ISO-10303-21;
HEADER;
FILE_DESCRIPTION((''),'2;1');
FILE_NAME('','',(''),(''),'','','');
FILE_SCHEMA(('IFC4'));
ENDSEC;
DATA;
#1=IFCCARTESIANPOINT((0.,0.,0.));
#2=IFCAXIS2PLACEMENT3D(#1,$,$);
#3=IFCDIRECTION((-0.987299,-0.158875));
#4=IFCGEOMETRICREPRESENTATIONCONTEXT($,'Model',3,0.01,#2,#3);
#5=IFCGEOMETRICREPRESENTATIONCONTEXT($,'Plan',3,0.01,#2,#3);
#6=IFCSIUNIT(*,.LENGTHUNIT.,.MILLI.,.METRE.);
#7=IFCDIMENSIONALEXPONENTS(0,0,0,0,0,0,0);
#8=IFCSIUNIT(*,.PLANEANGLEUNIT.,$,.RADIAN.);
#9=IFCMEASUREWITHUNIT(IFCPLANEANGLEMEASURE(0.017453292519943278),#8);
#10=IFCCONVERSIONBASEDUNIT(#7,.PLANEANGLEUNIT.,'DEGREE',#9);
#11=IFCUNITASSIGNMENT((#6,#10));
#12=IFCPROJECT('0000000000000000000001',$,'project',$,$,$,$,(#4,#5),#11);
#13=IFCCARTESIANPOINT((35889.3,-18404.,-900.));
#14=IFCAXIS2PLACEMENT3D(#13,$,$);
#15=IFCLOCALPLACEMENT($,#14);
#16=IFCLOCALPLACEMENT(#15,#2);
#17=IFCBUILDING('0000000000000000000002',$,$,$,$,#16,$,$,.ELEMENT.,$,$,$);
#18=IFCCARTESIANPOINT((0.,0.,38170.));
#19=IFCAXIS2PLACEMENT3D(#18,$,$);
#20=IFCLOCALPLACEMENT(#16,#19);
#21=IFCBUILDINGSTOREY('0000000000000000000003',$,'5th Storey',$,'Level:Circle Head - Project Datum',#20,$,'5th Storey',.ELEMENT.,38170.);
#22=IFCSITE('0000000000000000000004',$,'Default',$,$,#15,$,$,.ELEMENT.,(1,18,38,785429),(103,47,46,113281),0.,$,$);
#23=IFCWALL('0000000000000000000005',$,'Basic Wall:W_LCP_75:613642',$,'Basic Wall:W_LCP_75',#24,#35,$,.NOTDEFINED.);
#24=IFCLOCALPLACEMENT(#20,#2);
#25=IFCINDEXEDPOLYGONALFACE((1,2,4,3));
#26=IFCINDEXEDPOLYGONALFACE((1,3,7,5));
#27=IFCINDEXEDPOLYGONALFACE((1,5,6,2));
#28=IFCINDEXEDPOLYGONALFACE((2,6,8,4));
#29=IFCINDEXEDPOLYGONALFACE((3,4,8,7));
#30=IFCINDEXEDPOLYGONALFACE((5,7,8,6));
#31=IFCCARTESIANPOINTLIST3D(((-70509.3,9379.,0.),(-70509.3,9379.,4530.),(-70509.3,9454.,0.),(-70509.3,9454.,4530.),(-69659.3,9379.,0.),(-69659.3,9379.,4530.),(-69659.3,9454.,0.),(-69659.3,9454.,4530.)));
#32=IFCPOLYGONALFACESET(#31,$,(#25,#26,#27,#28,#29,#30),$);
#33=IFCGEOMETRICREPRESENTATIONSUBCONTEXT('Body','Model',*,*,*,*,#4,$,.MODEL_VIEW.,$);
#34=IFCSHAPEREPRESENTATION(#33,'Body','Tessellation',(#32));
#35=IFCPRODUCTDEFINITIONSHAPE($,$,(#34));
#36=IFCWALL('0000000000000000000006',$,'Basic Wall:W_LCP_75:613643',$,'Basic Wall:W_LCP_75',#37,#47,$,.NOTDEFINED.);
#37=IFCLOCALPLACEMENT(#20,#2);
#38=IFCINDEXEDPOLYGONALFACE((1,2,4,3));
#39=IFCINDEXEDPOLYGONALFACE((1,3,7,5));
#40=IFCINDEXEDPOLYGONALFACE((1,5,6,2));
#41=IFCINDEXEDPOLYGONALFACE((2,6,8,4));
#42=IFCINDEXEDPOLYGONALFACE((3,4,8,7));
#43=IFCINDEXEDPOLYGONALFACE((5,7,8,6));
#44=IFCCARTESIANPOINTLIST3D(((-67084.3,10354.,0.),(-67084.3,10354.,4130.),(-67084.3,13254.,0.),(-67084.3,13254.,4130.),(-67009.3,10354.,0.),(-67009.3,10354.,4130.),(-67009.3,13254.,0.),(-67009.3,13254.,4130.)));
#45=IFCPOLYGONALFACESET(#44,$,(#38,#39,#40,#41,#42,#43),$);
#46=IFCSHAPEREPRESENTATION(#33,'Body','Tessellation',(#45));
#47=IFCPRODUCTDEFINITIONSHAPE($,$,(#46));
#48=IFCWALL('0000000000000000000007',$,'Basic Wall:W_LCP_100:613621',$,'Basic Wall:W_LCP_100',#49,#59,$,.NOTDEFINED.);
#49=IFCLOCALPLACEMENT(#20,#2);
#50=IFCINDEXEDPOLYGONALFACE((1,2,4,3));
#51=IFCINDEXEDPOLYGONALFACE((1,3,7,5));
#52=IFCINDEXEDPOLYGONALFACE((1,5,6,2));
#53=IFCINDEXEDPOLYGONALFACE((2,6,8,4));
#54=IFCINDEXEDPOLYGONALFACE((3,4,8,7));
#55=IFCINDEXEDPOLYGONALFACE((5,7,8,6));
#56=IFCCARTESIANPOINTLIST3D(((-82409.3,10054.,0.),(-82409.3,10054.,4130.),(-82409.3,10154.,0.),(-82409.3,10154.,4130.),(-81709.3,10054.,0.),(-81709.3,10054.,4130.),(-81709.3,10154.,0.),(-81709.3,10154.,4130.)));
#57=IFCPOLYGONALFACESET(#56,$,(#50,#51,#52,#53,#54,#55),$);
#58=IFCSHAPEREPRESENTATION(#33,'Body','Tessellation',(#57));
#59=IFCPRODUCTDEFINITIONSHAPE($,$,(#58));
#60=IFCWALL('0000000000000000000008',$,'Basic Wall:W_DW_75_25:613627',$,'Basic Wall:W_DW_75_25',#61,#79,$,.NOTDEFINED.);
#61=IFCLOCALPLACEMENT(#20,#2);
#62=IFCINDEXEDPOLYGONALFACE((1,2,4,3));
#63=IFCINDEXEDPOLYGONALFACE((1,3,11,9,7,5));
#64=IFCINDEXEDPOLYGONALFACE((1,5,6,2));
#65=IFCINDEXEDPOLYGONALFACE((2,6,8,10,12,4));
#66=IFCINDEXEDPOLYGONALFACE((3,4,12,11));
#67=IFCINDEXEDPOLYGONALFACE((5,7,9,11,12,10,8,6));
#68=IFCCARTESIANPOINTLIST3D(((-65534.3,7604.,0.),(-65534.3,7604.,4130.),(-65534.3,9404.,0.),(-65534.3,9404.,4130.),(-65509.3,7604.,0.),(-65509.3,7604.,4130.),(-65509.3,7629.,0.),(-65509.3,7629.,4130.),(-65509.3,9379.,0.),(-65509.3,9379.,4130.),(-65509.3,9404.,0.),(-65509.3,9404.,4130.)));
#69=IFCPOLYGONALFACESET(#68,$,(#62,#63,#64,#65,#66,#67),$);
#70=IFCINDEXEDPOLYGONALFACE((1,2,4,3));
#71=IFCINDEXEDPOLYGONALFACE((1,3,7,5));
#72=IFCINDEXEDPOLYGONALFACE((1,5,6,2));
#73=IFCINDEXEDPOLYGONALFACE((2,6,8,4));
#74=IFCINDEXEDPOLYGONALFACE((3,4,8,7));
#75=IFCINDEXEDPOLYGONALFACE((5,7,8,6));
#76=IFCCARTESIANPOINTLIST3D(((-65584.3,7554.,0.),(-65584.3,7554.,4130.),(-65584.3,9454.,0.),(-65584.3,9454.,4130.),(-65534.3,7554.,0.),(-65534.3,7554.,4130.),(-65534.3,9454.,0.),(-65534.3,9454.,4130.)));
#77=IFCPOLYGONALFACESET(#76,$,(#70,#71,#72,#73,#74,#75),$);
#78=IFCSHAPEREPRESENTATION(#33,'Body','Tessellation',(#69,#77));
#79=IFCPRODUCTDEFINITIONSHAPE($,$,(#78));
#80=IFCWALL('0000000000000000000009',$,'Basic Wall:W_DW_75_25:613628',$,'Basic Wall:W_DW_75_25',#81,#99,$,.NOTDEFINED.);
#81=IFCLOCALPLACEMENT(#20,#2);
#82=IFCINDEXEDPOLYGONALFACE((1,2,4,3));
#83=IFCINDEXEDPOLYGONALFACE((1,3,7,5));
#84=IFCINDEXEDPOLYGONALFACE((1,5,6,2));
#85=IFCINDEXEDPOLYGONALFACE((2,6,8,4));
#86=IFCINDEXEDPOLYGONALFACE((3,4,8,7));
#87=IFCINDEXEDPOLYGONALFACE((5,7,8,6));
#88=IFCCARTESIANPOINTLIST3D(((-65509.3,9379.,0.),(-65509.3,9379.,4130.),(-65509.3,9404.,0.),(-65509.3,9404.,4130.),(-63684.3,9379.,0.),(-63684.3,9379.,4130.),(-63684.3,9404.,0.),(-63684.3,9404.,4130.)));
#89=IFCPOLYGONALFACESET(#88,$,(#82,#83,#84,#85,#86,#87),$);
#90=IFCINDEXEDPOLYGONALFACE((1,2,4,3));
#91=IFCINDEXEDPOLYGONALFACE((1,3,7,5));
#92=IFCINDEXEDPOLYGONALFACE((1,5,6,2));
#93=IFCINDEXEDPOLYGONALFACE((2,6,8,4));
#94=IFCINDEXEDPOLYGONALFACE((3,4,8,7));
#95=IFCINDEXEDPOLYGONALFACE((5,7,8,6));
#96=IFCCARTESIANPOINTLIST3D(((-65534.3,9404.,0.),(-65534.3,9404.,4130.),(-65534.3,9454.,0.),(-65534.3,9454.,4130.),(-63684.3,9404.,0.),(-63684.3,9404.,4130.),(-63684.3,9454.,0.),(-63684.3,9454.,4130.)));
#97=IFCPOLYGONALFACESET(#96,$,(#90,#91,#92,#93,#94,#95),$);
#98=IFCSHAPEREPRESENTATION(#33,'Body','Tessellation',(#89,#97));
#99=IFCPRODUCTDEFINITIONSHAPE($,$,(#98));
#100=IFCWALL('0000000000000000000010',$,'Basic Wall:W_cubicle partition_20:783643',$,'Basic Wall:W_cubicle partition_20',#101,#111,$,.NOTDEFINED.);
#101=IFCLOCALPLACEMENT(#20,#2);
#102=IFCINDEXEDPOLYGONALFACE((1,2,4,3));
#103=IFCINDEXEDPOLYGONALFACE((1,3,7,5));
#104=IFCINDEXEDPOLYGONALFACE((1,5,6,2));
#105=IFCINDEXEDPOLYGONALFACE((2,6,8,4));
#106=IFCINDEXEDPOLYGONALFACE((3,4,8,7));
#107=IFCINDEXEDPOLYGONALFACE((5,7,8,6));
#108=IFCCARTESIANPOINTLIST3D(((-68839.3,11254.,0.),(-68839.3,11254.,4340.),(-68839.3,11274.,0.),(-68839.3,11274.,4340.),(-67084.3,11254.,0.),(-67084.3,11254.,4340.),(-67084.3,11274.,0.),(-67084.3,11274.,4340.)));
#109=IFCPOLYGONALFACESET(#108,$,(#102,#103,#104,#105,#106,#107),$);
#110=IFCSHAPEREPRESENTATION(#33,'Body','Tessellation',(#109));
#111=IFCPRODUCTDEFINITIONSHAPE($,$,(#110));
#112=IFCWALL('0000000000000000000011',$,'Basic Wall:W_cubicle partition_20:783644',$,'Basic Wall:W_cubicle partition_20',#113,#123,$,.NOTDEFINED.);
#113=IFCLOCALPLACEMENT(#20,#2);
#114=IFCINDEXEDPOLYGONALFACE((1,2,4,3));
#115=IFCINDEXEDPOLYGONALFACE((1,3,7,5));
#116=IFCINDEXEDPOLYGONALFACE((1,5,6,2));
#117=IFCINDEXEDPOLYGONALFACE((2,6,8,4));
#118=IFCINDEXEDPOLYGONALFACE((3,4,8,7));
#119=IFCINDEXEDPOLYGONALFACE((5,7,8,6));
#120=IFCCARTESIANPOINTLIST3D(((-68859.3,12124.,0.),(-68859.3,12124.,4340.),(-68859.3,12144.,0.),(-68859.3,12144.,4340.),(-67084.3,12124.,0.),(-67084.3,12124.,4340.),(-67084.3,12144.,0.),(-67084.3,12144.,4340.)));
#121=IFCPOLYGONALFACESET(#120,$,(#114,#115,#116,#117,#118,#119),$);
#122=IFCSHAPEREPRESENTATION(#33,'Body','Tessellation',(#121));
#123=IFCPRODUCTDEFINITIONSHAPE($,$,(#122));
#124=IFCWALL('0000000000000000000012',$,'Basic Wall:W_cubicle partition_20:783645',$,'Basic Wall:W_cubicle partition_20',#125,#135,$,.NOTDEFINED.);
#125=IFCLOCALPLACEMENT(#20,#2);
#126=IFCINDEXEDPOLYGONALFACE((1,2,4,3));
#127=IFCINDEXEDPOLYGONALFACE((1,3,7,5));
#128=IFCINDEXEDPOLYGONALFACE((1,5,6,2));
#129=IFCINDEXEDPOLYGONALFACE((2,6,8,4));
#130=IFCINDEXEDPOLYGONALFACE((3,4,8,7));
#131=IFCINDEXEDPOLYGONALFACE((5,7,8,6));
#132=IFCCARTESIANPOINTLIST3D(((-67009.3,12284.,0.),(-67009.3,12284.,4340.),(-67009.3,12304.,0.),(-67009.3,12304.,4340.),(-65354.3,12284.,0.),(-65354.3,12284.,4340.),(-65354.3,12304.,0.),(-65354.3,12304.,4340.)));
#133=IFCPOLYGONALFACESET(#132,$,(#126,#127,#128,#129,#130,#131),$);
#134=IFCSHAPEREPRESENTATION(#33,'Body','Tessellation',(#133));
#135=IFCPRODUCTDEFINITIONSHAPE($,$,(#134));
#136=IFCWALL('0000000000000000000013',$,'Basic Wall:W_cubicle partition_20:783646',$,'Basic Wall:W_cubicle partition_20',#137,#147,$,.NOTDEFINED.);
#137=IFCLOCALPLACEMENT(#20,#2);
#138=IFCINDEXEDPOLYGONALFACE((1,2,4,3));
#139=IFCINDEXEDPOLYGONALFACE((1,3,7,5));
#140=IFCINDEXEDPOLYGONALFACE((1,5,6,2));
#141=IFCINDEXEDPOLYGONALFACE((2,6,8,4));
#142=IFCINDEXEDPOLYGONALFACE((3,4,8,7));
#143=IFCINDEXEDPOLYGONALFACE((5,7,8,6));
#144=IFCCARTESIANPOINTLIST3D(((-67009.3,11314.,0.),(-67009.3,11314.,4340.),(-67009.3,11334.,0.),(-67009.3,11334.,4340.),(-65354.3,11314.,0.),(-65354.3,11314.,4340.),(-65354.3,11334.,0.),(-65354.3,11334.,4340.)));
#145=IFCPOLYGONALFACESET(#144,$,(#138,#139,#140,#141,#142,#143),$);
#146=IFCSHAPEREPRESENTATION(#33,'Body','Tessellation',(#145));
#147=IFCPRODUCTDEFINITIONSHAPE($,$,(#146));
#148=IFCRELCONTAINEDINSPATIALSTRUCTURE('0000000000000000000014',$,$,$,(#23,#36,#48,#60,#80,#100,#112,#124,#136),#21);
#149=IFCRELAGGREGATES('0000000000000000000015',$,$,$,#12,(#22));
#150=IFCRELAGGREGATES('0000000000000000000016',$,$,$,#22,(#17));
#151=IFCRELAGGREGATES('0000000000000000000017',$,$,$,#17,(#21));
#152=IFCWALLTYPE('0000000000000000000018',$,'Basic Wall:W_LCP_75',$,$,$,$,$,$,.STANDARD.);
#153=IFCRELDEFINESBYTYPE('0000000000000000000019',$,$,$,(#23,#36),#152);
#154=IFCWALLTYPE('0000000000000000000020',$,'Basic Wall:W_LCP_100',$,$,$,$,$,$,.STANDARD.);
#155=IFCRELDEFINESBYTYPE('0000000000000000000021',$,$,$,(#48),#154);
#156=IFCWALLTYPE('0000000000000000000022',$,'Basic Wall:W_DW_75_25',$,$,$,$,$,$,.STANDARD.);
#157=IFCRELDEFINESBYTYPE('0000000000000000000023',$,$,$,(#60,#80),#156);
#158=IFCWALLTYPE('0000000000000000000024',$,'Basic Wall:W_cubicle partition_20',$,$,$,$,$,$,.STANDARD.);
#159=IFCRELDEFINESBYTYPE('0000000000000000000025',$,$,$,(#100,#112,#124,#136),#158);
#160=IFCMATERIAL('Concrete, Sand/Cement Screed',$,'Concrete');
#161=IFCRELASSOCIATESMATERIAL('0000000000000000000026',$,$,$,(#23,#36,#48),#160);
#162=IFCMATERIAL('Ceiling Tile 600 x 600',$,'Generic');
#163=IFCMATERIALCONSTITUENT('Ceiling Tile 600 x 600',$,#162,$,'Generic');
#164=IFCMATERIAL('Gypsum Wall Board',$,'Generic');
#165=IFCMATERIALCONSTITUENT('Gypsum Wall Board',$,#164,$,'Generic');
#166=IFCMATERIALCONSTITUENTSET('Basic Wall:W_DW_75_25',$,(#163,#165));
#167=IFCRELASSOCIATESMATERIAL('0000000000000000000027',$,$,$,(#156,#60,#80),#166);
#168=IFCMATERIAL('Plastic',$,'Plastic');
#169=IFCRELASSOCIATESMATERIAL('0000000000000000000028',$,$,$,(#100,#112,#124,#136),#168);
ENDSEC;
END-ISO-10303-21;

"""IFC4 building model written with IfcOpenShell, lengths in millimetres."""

from ifc_helpers import new_model, entity, si_unit, converted_unit, direction, frame, origin, place, context, subcontext, project, spatial, indexed_curve, outline, extrude, material, constituent, constituent_set, type_object, element, save


model = new_model("IFC4")

# Units and contexts
model_context = context("Model", 3, precision=0.01, world=origin(), true_north=direction((-0.987299, -0.158875)))
plan_context = context("Plan", 3, precision=0.01, world=origin(), true_north=direction((-0.987299, -0.158875)))
body_context = subcontext(model_context, "Body", "Model", "MODEL_VIEW")
ifc_project = project(units=[si_unit("LENGTHUNIT", "METRE", prefix="MILLI"), converted_unit("PLANEANGLEUNIT", "DEGREE", entity("IfcPlaneAngleMeasure", 0.017453292519943278), si_unit("PLANEANGLEUNIT", "RADIAN"), dimensions=[0, 0, 0, 0, 0, 0, 0])], contexts=[model_context, plan_context])

# Site, building, storey
site_placement = place(None, frame((35889.3, -18404.0, -900.0)))
site = spatial("IfcSite", under=ifc_project, at=site_placement, Name="Default", CompositionType="ELEMENT", RefLatitude=(1, 18, 38, 785429), RefLongitude=(103, 47, 46, 113281), RefElevation=0.0)
building_placement = place(site_placement, origin())
building = spatial("IfcBuilding", under=site, at=building_placement, CompositionType="ELEMENT")
storey_placement = place(building_placement, frame((0.0, 0.0, 38170.0)))
storey = spatial("IfcBuildingStorey", under=building, at=storey_placement, Name="5th Storey", ObjectType="Level:Circle Head - Project Datum", LongName="5th Storey", CompositionType="ELEMENT", Elevation=38170.0)

# Walls
ifc_material_1 = material(Name="Concrete, Sand/Cement Screed", Category="Concrete")
wall_type_1 = type_object("IfcWallType", Name="Basic Wall:W_LCP_75", PredefinedType="STANDARD")
wall_1_placement = place(storey_placement, frame((-70509.3, 9416.5, 0.0)))
element("IfcWall", 1, at=wall_1_placement, inside=storey, type_object=wall_type_1, material=ifc_material_1, Name="Basic Wall:W_LCP_75:613642", ObjectType="Basic Wall:W_LCP_75", PredefinedType="NOTDEFINED", context=body_context, shape_type="SweptSolid", body=[
    extrude(outline(indexed_curve([(850.0, 37.5), (0.0, 37.5), (0.0, -37.5), (850.0, -37.5), (850.0, 37.5)], self_intersect=False)), origin(), (0.0, 0.0, 1.0), 4530.0),
])
wall_2_placement = place(storey_placement, frame((-67046.8, 13254.0, 0.0), z_axis=(0.0, 0.0, 1.0), x_axis=(0.0, -1.0, 0.0)))
element("IfcWall", 2, at=wall_2_placement, inside=storey, type_object=wall_type_1, material=ifc_material_1, Name="Basic Wall:W_LCP_75:613643", ObjectType="Basic Wall:W_LCP_75", PredefinedType="NOTDEFINED", context=body_context, shape_type="SweptSolid", body=[
    extrude(outline(indexed_curve([(2900.0, 37.5), (0.0, 37.5), (0.0, -37.5), (2900.0, -37.5), (2900.0, 37.5)], self_intersect=False)), origin(), (0.0, 0.0, 1.0), 4130.0),
])
wall_type_2 = type_object("IfcWallType", Name="Basic Wall:W_LCP_100", PredefinedType="STANDARD")
wall_3_placement = place(storey_placement, frame((-81709.3, 10104.0, 0.0), z_axis=(0.0, 0.0, 1.0), x_axis=(-1.0, 0.0, 0.0)))
element("IfcWall", 3, at=wall_3_placement, inside=storey, type_object=wall_type_2, material=ifc_material_1, Name="Basic Wall:W_LCP_100:613621", ObjectType="Basic Wall:W_LCP_100", PredefinedType="NOTDEFINED", context=body_context, shape_type="SweptSolid", body=[
    extrude(outline(indexed_curve([(700.0, 50.0), (0.0, 50.0), (0.0, -50.0), (700.0, -50.0), (700.0, 50.0)], self_intersect=False)), origin(), (0.0, 0.0, 1.0), 4130.0),
])
ifc_material_2 = material(Name="Ceiling Tile 600 x 600", Category="Generic")
ifc_constituent_1 = constituent(ifc_material_2, Name="Ceiling Tile 600 x 600", Category="Generic")
ifc_material_3 = material(Name="Gypsum Wall Board", Category="Generic")
ifc_constituent_2 = constituent(ifc_material_3, Name="Gypsum Wall Board", Category="Generic")
ifc_constituent_set = constituent_set(constituents=[ifc_constituent_1, ifc_constituent_2], Name="Basic Wall:W_DW_75_25")
wall_type_3 = type_object("IfcWallType", Name="Basic Wall:W_DW_75_25", PredefinedType="STANDARD", material=ifc_constituent_set)
wall_4_placement = place(storey_placement, frame((-65546.8, 9454.0, 0.0), z_axis=(0.0, 0.0, 1.0), x_axis=(0.0, -1.0, 0.0)))
element("IfcWall", 4, at=wall_4_placement, inside=storey, type_object=wall_type_3, material=ifc_constituent_set, Name="Basic Wall:W_DW_75_25:613627", ObjectType="Basic Wall:W_DW_75_25", PredefinedType="NOTDEFINED", context=body_context, shape_type="SweptSolid", body=[
    extrude(outline(indexed_curve([(-875.0, -8.3), (875.0, -8.3), (900.0, -8.3), (900.0, 16.7), (-900.0, 16.7), (-900.0, -8.3), (-875.0, -8.3)], self_intersect=False)), frame((950.0, 29.2, 0.0), z_axis=(0.0, 0.0, 1.0), x_axis=(-1.0, 0.0, 0.0)), (0.0, 0.0, 1.0), 4130.0),
    extrude(outline(indexed_curve([(-25.0, -950.0), (25.0, -950.0), (25.0, 950.0), (-25.0, 950.0), (-25.0, -950.0)], self_intersect=False)), frame((950.0, -12.5, 0.0), z_axis=(0.0, 0.0, 1.0), x_axis=(0.0, 1.0, 0.0)), (0.0, 0.0, 1.0), 4130.0),
])
wall_5_placement = place(storey_placement, frame((-65509.3, 9416.5, 0.0)))
element("IfcWall", 5, at=wall_5_placement, inside=storey, type_object=wall_type_3, material=ifc_constituent_set, Name="Basic Wall:W_DW_75_25:613628", ObjectType="Basic Wall:W_DW_75_25", PredefinedType="NOTDEFINED", context=body_context, shape_type="SweptSolid", body=[
    extrude(outline(indexed_curve([(-12.5, -912.5), (12.5, -912.5), (12.5, 912.5), (-12.5, 912.5), (-12.5, -912.5)], self_intersect=False)), frame((912.5, -25.0, 0.0), z_axis=(0.0, 0.0, 1.0), x_axis=(0.0, 1.0, 0.0)), (0.0, 0.0, 1.0), 4130.0),
    extrude(outline(indexed_curve([(-25.0, -925.0), (25.0, -925.0), (25.0, 925.0), (-25.0, 925.0), (-25.0, -925.0)], self_intersect=False)), frame((900.0, 12.5, 0.0), z_axis=(0.0, 0.0, 1.0), x_axis=(0.0, -1.0, 0.0)), (0.0, 0.0, 1.0), 4130.0),
])
ifc_material_4 = material(Name="Plastic", Category="Plastic")
wall_type_4 = type_object("IfcWallType", Name="Basic Wall:W_cubicle partition_20", PredefinedType="STANDARD")
wall_6_placement = place(storey_placement, frame((-68839.3, 11264.0, 0.0)))
element("IfcWall", 6, at=wall_6_placement, inside=storey, type_object=wall_type_4, material=ifc_material_4, Name="Basic Wall:W_cubicle partition_20:783643", ObjectType="Basic Wall:W_cubicle partition_20", PredefinedType="NOTDEFINED", context=body_context, shape_type="SweptSolid", body=[
    extrude(outline(indexed_curve([(1755.0, 10.0), (0.0, 10.0), (0.0, -10.0), (1755.0, -10.0), (1755.0, 10.0)], self_intersect=False)), origin(), (0.0, 0.0, 1.0), 4340.0),
])
wall_7_placement = place(storey_placement, frame((-68859.3, 12134.0, 0.0)))
element("IfcWall", 7, at=wall_7_placement, inside=storey, type_object=wall_type_4, material=ifc_material_4, Name="Basic Wall:W_cubicle partition_20:783644", ObjectType="Basic Wall:W_cubicle partition_20", PredefinedType="NOTDEFINED", context=body_context, shape_type="SweptSolid", body=[
    extrude(outline(indexed_curve([(1775.0, 10.0), (0.0, 10.0), (0.0, -10.0), (1775.0, -10.0), (1775.0, 10.0)], self_intersect=False)), origin(), (0.0, 0.0, 1.0), 4340.0),
])
for number, where, name in (
    (8, (-67009.3, 12294.0, 0.0), "Basic Wall:W_cubicle partition_20:783645"),
    (9, (-67009.3, 11324.0, 0.0), "Basic Wall:W_cubicle partition_20:783646"),
):
    element("IfcWall", number, at=place(storey_placement, frame(where)), inside=storey, type_object=wall_type_4, material=ifc_material_4, Name=name, ObjectType="Basic Wall:W_cubicle partition_20", PredefinedType="NOTDEFINED", context=body_context, shape_type="SweptSolid", body=[
        extrude(outline(indexed_curve([(1655.0, 10.0), (0.0, 10.0), (0.0, -10.0), (1655.0, -10.0), (1655.0, 10.0)], self_intersect=False)), origin(), (0.0, 0.0, 1.0), 4340.0),
    ])

save(model, "model.ifc")
